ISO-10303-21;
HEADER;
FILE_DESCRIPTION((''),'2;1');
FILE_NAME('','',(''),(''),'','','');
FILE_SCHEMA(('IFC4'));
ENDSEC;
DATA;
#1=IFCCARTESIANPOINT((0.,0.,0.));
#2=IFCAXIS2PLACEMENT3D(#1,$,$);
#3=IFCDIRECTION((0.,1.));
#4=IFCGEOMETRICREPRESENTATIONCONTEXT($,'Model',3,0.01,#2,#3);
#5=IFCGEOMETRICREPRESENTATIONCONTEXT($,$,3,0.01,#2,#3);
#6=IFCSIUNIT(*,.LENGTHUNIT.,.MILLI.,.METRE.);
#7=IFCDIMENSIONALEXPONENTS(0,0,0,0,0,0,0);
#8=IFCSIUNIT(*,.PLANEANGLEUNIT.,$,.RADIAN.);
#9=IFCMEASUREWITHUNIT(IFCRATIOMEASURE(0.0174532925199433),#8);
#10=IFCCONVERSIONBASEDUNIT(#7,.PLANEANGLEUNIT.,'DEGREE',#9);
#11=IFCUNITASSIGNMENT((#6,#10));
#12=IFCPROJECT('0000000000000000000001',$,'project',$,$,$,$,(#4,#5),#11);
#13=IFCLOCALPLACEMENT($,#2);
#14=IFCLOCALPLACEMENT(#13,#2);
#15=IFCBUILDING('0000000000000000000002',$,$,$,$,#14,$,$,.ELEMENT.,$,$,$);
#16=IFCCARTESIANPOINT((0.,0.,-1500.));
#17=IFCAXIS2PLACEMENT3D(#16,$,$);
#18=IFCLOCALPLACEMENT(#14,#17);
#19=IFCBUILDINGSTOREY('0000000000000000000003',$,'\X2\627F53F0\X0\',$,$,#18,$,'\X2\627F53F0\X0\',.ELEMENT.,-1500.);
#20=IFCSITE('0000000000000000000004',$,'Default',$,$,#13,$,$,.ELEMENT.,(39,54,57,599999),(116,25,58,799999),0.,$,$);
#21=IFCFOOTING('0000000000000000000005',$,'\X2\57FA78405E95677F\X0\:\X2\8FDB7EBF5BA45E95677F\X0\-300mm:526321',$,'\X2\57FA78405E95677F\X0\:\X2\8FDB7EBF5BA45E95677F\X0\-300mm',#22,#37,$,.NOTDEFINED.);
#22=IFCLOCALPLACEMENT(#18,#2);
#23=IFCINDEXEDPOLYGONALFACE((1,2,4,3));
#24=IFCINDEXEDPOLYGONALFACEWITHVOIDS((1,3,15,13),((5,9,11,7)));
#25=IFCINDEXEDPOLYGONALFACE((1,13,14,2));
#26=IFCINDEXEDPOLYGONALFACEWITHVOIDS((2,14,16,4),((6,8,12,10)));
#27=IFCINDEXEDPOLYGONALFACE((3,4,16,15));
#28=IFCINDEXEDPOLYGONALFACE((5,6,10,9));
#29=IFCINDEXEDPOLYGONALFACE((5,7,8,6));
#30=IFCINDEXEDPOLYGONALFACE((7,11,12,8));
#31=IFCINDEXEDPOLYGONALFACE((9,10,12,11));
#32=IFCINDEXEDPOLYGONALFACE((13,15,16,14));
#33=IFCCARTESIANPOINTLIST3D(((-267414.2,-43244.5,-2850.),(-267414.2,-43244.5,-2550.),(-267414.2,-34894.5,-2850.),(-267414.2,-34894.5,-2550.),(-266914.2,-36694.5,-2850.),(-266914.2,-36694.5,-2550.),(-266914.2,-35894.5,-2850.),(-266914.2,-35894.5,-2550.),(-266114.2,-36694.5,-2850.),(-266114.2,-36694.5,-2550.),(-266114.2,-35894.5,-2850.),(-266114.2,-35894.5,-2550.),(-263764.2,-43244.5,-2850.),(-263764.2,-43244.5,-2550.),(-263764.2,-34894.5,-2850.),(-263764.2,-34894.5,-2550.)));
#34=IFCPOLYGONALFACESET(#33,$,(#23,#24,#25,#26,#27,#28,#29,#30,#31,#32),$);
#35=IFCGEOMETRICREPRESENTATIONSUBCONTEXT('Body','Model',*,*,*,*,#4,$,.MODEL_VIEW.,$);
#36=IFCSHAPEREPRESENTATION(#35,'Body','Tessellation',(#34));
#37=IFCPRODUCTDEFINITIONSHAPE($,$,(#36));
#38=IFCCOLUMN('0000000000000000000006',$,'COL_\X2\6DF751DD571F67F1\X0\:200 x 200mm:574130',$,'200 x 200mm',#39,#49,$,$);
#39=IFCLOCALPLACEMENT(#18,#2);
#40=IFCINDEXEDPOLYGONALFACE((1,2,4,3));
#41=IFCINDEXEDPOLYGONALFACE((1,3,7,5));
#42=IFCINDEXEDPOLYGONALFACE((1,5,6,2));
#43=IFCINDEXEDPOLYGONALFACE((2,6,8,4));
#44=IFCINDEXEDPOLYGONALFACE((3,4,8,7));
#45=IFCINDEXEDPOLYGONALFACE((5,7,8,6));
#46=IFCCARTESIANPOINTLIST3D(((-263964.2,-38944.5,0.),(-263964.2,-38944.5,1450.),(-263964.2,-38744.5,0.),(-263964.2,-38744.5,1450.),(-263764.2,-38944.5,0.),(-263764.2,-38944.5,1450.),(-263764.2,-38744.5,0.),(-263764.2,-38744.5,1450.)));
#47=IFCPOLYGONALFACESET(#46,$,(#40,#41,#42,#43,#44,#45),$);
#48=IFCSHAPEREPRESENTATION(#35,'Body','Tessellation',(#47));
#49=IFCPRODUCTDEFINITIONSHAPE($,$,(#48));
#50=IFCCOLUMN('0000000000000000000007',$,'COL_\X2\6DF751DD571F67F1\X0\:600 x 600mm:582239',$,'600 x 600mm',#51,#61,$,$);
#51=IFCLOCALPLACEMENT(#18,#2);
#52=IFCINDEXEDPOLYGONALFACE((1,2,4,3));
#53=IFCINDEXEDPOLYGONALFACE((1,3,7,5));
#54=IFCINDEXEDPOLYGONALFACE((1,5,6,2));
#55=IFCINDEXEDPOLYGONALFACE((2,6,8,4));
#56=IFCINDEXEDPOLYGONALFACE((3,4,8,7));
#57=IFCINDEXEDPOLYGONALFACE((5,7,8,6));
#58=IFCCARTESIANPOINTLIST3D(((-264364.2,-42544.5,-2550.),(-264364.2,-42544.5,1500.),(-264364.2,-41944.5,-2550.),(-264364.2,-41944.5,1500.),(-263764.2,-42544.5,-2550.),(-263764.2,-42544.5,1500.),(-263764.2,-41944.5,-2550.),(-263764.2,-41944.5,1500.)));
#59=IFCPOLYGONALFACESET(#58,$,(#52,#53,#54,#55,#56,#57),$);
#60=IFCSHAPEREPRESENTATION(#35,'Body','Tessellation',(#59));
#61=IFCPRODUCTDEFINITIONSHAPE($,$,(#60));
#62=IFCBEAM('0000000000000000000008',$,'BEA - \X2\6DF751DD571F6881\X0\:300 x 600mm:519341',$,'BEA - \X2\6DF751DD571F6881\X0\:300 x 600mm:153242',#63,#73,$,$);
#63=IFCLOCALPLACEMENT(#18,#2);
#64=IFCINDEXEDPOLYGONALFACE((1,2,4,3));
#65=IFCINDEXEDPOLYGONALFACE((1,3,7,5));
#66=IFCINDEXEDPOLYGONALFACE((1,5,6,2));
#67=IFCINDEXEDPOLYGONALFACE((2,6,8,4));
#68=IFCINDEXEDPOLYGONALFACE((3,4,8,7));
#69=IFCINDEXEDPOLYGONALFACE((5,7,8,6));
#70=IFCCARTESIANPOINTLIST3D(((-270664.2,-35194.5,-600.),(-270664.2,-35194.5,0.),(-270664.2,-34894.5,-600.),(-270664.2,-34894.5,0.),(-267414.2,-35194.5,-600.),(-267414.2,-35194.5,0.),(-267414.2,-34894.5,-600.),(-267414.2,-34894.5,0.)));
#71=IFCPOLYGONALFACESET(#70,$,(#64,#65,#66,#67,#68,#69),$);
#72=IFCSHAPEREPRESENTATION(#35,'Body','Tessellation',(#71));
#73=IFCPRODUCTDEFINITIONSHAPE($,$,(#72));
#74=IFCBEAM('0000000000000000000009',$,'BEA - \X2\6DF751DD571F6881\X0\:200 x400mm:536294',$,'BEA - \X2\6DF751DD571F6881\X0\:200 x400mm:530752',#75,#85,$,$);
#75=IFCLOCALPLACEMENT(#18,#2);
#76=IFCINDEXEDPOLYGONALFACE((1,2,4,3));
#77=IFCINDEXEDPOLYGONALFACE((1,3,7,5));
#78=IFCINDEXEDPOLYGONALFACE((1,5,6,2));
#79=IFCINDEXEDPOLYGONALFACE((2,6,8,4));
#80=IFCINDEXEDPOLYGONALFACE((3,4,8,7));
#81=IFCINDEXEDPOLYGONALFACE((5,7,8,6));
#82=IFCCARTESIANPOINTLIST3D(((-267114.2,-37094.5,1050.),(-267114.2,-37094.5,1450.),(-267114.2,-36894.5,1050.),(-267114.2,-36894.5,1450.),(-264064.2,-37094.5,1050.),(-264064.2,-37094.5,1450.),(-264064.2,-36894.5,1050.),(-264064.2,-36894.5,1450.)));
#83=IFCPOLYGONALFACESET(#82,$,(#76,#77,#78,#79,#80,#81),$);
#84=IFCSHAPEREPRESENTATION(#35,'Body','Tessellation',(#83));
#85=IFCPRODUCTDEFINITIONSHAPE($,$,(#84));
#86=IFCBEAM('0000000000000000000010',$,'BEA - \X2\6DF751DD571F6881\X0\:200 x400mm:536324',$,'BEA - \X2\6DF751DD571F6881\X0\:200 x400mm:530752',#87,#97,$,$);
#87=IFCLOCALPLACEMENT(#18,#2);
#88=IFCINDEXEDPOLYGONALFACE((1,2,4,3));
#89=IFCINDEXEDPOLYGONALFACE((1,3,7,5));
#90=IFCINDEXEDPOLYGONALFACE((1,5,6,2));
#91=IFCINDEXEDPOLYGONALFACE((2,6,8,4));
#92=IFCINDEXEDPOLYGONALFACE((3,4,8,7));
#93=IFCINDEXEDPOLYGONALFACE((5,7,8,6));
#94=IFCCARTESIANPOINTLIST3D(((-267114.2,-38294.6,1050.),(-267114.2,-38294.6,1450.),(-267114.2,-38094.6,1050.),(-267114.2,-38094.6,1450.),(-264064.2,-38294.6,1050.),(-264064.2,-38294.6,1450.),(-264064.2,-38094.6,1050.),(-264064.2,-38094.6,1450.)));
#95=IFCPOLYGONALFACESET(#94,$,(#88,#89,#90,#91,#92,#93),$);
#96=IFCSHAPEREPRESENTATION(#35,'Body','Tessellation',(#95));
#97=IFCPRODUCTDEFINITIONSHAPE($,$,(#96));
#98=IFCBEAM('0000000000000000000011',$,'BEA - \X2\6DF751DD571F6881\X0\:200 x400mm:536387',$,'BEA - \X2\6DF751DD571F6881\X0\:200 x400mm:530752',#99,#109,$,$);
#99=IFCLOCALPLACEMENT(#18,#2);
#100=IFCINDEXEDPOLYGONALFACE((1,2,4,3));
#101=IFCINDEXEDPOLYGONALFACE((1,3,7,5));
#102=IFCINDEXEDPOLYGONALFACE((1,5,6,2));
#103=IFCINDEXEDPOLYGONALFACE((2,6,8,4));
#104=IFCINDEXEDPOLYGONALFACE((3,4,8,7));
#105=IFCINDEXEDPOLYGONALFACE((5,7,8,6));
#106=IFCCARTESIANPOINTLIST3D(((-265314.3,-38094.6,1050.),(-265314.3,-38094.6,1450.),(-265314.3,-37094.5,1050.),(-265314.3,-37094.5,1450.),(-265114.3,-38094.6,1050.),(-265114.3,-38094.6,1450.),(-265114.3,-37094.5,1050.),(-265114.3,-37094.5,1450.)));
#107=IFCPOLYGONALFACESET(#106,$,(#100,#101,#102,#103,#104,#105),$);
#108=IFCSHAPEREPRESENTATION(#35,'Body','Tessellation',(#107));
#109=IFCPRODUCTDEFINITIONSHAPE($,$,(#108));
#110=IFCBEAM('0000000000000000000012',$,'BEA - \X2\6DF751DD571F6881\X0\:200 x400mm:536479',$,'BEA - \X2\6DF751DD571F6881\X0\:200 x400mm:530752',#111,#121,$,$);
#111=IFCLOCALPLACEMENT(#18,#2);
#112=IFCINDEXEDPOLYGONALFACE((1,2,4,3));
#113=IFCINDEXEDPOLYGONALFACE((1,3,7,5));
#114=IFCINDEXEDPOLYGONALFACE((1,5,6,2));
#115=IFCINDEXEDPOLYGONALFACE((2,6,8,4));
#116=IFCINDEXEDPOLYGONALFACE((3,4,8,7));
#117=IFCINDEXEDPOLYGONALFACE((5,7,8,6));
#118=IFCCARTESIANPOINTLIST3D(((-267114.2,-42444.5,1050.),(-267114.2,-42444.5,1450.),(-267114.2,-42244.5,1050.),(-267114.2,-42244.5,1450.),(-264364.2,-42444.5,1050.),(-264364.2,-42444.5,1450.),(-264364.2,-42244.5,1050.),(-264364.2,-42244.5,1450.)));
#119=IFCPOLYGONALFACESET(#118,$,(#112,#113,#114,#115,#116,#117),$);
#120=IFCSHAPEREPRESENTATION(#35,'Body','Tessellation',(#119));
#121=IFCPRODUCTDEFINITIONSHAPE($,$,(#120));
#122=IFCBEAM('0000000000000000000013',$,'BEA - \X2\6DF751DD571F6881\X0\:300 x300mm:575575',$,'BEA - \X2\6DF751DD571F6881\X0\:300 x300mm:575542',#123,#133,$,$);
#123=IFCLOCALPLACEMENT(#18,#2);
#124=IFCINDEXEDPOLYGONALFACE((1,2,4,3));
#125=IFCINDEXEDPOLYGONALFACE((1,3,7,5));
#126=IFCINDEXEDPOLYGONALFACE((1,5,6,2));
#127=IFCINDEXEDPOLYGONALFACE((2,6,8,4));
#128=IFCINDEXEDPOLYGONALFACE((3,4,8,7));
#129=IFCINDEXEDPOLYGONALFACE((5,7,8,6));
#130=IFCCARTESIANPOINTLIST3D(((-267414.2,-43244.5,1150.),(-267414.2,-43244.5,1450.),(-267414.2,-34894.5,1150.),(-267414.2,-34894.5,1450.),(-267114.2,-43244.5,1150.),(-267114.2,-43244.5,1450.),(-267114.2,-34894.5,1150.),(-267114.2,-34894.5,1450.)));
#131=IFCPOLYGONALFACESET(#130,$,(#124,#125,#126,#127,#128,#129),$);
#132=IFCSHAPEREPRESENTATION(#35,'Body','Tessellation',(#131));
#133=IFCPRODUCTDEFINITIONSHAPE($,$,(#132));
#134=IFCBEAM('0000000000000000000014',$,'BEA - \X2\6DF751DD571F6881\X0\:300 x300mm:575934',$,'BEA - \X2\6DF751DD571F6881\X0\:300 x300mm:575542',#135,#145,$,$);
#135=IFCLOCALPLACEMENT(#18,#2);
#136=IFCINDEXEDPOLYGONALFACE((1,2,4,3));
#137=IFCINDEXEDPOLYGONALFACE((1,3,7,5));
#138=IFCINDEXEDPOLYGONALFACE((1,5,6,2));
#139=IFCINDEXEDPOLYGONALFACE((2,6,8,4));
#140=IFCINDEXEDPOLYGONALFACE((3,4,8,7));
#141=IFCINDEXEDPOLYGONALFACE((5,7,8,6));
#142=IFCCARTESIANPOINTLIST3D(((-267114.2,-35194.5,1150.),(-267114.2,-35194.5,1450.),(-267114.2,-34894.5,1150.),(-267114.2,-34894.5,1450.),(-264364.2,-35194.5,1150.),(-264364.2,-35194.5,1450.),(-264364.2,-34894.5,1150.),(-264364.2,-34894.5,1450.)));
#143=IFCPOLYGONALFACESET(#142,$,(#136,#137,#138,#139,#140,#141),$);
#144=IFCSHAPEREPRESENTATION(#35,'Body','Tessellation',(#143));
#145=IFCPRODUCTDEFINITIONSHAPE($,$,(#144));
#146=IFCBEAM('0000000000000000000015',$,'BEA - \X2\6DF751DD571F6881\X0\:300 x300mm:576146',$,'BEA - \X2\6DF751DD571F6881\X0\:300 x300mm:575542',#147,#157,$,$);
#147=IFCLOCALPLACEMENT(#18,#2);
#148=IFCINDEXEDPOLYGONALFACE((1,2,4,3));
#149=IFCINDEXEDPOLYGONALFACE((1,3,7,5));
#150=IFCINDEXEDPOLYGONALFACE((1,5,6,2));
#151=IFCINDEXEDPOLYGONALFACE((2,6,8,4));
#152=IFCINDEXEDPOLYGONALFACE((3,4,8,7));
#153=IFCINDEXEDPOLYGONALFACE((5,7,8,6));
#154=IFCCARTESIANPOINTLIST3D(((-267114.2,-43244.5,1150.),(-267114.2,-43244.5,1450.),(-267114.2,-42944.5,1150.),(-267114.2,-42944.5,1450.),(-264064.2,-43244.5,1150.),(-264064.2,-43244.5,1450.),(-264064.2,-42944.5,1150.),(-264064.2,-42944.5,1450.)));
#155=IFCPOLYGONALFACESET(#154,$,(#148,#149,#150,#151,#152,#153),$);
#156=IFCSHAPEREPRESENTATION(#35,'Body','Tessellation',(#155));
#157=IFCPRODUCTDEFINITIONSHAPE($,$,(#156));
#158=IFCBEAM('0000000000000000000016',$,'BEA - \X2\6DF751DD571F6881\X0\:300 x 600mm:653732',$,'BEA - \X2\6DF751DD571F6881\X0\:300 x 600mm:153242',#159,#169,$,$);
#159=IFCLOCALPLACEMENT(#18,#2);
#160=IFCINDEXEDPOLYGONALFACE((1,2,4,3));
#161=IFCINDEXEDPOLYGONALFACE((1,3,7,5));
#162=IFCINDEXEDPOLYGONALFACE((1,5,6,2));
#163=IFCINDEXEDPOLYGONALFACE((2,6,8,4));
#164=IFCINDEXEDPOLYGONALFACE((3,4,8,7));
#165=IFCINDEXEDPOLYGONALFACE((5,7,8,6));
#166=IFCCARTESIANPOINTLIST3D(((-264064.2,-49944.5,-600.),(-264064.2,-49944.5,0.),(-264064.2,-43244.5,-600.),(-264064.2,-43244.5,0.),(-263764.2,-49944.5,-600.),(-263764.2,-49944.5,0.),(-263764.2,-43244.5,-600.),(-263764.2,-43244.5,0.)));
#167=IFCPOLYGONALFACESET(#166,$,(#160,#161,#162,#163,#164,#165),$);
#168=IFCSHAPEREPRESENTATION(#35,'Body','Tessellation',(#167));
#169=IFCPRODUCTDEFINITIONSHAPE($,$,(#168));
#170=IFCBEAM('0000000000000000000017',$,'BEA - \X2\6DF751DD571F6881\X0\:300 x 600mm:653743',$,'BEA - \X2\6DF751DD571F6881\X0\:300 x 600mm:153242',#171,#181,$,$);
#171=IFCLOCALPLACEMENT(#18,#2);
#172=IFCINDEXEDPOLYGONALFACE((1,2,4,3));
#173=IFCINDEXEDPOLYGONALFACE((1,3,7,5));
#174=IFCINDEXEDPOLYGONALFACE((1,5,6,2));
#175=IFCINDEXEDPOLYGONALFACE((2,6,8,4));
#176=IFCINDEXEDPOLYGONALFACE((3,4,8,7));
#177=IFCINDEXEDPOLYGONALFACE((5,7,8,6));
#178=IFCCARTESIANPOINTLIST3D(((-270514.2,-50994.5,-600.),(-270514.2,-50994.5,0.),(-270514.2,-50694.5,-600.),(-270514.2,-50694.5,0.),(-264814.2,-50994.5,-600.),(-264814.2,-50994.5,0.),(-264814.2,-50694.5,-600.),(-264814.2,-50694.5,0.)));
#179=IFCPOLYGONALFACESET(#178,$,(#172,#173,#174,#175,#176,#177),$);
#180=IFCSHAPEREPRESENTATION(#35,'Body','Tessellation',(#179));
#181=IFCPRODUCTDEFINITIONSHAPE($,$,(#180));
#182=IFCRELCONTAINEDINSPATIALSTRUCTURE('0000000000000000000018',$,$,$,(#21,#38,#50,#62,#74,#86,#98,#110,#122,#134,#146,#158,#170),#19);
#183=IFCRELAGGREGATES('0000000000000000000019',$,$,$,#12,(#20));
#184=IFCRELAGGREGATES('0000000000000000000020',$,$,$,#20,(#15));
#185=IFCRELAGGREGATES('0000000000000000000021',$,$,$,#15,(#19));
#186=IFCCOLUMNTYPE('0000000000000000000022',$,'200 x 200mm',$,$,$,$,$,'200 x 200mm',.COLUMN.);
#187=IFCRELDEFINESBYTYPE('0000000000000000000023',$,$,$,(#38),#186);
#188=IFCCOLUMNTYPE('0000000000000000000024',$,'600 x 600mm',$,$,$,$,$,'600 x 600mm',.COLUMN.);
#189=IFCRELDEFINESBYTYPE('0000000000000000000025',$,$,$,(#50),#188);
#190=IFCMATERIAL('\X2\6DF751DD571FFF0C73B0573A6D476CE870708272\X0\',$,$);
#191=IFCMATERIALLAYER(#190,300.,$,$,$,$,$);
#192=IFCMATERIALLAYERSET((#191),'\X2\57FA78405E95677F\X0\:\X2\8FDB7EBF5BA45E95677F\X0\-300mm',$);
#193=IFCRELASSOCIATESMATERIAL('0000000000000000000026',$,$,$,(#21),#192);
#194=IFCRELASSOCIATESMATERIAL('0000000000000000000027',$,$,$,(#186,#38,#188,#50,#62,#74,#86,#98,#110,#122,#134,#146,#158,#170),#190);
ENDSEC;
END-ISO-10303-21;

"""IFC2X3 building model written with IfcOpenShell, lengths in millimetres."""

from ifc_helpers import new_model, entity, si_unit, converted_unit, direction, frame, frame_2d, origin, origin_2d_with_axis, place, context, subcontext, project, spatial, rectangle, extrude, source, transform, mapped, material, layer, layer_set, layer_usage, type_object, type_shapes, element, save


model = new_model("IFC2X3")

# Units and contexts
model_context = context("Model", 3, precision=0.01, world=origin(), true_north=direction((0.0, 1.0)))
context_of_model = context(None, 3, precision=0.01, world=origin(), true_north=direction((0.0, 1.0)))
body_context = subcontext(model_context, "Body", "Model", "MODEL_VIEW")
ifc_project = project(units=[si_unit("LENGTHUNIT", "METRE", prefix="MILLI"), converted_unit("PLANEANGLEUNIT", "DEGREE", entity("IfcRatioMeasure", 0.0174532925199433), si_unit("PLANEANGLEUNIT", "RADIAN"), dimensions=[0, 0, 0, 0, 0, 0, 0])], contexts=[model_context, context_of_model])

# Site, building, storey
site_placement = place(None, origin())
site = spatial("IfcSite", under=ifc_project, at=site_placement, Name="Default", CompositionType="ELEMENT", RefLatitude=(39, 54, 57, 599999), RefLongitude=(116, 25, 58, 799999), RefElevation=0.0)
building_placement = place(site_placement, origin())
building = spatial("IfcBuilding", under=site, at=building_placement, CompositionType="ELEMENT")
storey_placement = place(building_placement, frame((0.0, 0.0, -1500.0)))
storey = spatial("IfcBuildingStorey", under=building, at=storey_placement, Name="承台", LongName="承台", CompositionType="ELEMENT", Elevation=-1500.0)

# Footing, opening
ifc_material_1 = material(Name="混凝土，现场浇注灰色")
ifc_layer_1 = layer(ifc_material_1, 300.0)
ifc_layer_set_1 = layer_set([ifc_layer_1], Name="基础底板:进线室底板-300mm")
ifc_layer_usage_1 = layer_usage(ifc_layer_set_1, "AXIS3", "POSITIVE", 0.0)
footing_1_placement = place(storey_placement, frame((-267414.2, -43244.5, -2850.0)))
footing_1 = element("IfcFooting", 1, at=footing_1_placement, inside=storey, material=ifc_layer_usage_1, Name="基础底板:进线室底板-300mm:526321", ObjectType="基础底板:进线室底板-300mm", PredefinedType="NOTDEFINED", context=body_context, shape_type="SweptSolid", body=[
    extrude(rectangle(XDim=3650.0, YDim=8350.0, at=frame_2d((0.0, 0.0), x_axis=(-1.0, 0.0))), frame((1825.0, 4175.0, 300.0), z_axis=(0.0, 0.0, -1.0), x_axis=(-1.0, 0.0, 0.0)), (0.0, 0.0, 1.0), 300.0),
])
opening_1_placement = place(footing_1_placement, frame((900.0, 6950.0, 300.0)))
element("IfcOpeningElement", 2, at=opening_1_placement, cuts=footing_1, ObjectType="Opening", context=body_context, shape_type="SweptSolid", body=[
    extrude(rectangle(XDim=800.0, YDim=800.0, at=origin_2d_with_axis()), frame((0.0, 0.0, 0.0), z_axis=(0.0, 0.0, -1.0), x_axis=(0.0, 1.0, 0.0)), (0.0, 0.0, 1.0), 300.0),
])

# Columns
column_type_1 = type_object("IfcColumnType", Name="200 x 200mm", ElementType="200 x 200mm", PredefinedType="COLUMN", material=ifc_material_1)
shared_shape_1 = source(origin(), body_context, "Body", "SweptSolid", [
    extrude(rectangle(XDim=200.0, YDim=200.0, at=frame_2d((0.0, 0.0), x_axis=(1.0, 0.0))), frame((100.0, 100.0, 0.0), z_axis=(0.0, 0.0, 1.0), x_axis=(-1.0, 0.0, 0.0)), (0.0, 0.0, 1.0), 1450.0),
])
type_shapes(column_type_1, [shared_shape_1])
column_1_placement = place(storey_placement, frame((-263964.2, -38944.5, 0.0)))
element("IfcColumn", 3, at=column_1_placement, inside=storey, type_object=column_type_1, material=ifc_material_1, Name="COL_混凝土柱:200 x 200mm:574130", ObjectType="200 x 200mm", context=body_context, shape_type="MappedRepresentation", body=[
    mapped(shared_shape_1, transform((0.0, 0.0, 0.0), scale=1.0)),
])
column_type_2 = type_object("IfcColumnType", Name="600 x 600mm", ElementType="600 x 600mm", PredefinedType="COLUMN", material=ifc_material_1)
shared_shape_2 = source(origin(), body_context, "Body", "SweptSolid", [
    extrude(rectangle(XDim=600.0, YDim=600.0, at=frame_2d((0.0, 0.0), x_axis=(1.0, 0.0))), frame((300.0, 300.0, 0.0), z_axis=(0.0, 0.0, 1.0), x_axis=(-1.0, 0.0, 0.0)), (0.0, 0.0, 1.0), 4050.0),
])
type_shapes(column_type_2, [shared_shape_2])
column_2_placement = place(storey_placement, frame((-264364.2, -42544.5, -2550.0)))
element("IfcColumn", 4, at=column_2_placement, inside=storey, type_object=column_type_2, material=ifc_material_1, Name="COL_混凝土柱:600 x 600mm:582239", ObjectType="600 x 600mm", context=body_context, shape_type="MappedRepresentation", body=[
    mapped(shared_shape_2, transform((0.0, 0.0, 0.0), scale=1.0)),
])

# Beams
beam_1_placement = place(storey_placement, frame((-267264.2, -35044.5, 0.0), z_axis=(0.0, 0.0, 1.0), x_axis=(-1.0, 0.0, 0.0)))
element("IfcBeam", 5, at=beam_1_placement, inside=storey, material=ifc_material_1, Name="BEA - 混凝土梁:300 x 600mm:519341", ObjectType="BEA - 混凝土梁:300 x 600mm:153242", context=body_context, shape_type="SweptSolid", body=[
    extrude(rectangle(XDim=600.0, YDim=300.0, at=frame_2d((0.0, 0.0), x_axis=(1.0, 0.0))), frame((150.0, 0.0, -300.0), z_axis=(1.0, 0.0, 0.0), x_axis=(0.0, 0.0, -1.0)), (0.0, 0.0, 1.0), 3250.0),
])
beam_2_placement = place(storey_placement, frame((-267114.2, -36994.5, 1450.0)))
element("IfcBeam", 6, at=beam_2_placement, inside=storey, material=ifc_material_1, Name="BEA - 混凝土梁:200 x400mm:536294", ObjectType="BEA - 混凝土梁:200 x400mm:530752", context=body_context, shape_type="SweptSolid", body=[
    extrude(rectangle(XDim=400.0, YDim=200.0, at=frame_2d((0.0, 0.0), x_axis=(1.0, 0.0))), frame((0.0, 0.0, -200.0), z_axis=(1.0, 0.0, 0.0), x_axis=(0.0, 0.0, -1.0)), (0.0, 0.0, 1.0), 3050.0),
])
beam_3_placement = place(storey_placement, frame((-267114.2, -38194.6, 1450.0)))
element("IfcBeam", 7, at=beam_3_placement, inside=storey, material=ifc_material_1, Name="BEA - 混凝土梁:200 x400mm:536324", ObjectType="BEA - 混凝土梁:200 x400mm:530752", context=body_context, shape_type="SweptSolid", body=[
    extrude(rectangle(XDim=400.0, YDim=200.0, at=frame_2d((0.0, 0.0), x_axis=(1.0, 0.0))), frame((0.0, 0.0, -200.0), z_axis=(1.0, 0.0, 0.0), x_axis=(0.0, 0.0, -1.0)), (0.0, 0.0, 1.0), 3050.0),
])
beam_4_placement = place(storey_placement, frame((-265214.3, -37094.5, 1450.0), z_axis=(0.0, 0.0, 1.0), x_axis=(0.0, -1.0, 0.0)))
element("IfcBeam", 8, at=beam_4_placement, inside=storey, material=ifc_material_1, Name="BEA - 混凝土梁:200 x400mm:536387", ObjectType="BEA - 混凝土梁:200 x400mm:530752", context=body_context, shape_type="SweptSolid", body=[
    extrude(rectangle(XDim=400.0, YDim=200.0, at=frame_2d((0.0, 0.0), x_axis=(1.0, 0.0))), frame((0.0, 0.0, -200.0), z_axis=(1.0, 0.0, 0.0), x_axis=(0.0, 0.0, -1.0)), (0.0, 0.0, 1.0), 1000.1),
])
beam_5_placement = place(storey_placement, frame((-267114.2, -42344.5, 1450.0)))
element("IfcBeam", 9, at=beam_5_placement, inside=storey, material=ifc_material_1, Name="BEA - 混凝土梁:200 x400mm:536479", ObjectType="BEA - 混凝土梁:200 x400mm:530752", context=body_context, shape_type="SweptSolid", body=[
    extrude(rectangle(XDim=400.0, YDim=200.0, at=frame_2d((0.0, 0.0), x_axis=(1.0, 0.0))), frame((0.0, 0.0, -200.0), z_axis=(1.0, 0.0, 0.0), x_axis=(0.0, 0.0, -1.0)), (0.0, 0.0, 1.0), 2750.0),
])
beam_6_placement = place(storey_placement, frame((-267264.2, -43094.5, 1450.0), z_axis=(0.0, 0.0, 1.0), x_axis=(0.0, 1.0, 0.0)))
element("IfcBeam", 10, at=beam_6_placement, inside=storey, material=ifc_material_1, Name="BEA - 混凝土梁:300 x300mm:575575", ObjectType="BEA - 混凝土梁:300 x300mm:575542", context=body_context, shape_type="SweptSolid", body=[
    extrude(rectangle(XDim=300.0, YDim=300.0, at=frame_2d((0.0, 0.0), x_axis=(1.0, 0.0))), frame((-150.0, 0.0, -150.0), z_axis=(1.0, 0.0, 0.0), x_axis=(0.0, 0.0, -1.0)), (0.0, 0.0, 1.0), 8350.0),
])
beam_7_placement = place(storey_placement, frame((-267114.2, -35044.5, 1450.0)))
element("IfcBeam", 11, at=beam_7_placement, inside=storey, material=ifc_material_1, Name="BEA - 混凝土梁:300 x300mm:575934", ObjectType="BEA - 混凝土梁:300 x300mm:575542", context=body_context, shape_type="SweptSolid", body=[
    extrude(rectangle(XDim=300.0, YDim=300.0, at=frame_2d((0.0, 0.0), x_axis=(1.0, 0.0))), frame((0.0, 0.0, -150.0), z_axis=(1.0, 0.0, 0.0), x_axis=(0.0, 0.0, -1.0)), (0.0, 0.0, 1.0), 2750.0),
])
beam_8_placement = place(storey_placement, frame((-267114.2, -43094.5, 1450.0)))
element("IfcBeam", 12, at=beam_8_placement, inside=storey, material=ifc_material_1, Name="BEA - 混凝土梁:300 x300mm:576146", ObjectType="BEA - 混凝土梁:300 x300mm:575542", context=body_context, shape_type="SweptSolid", body=[
    extrude(rectangle(XDim=300.0, YDim=300.0, at=frame_2d((0.0, 0.0), x_axis=(1.0, 0.0))), frame((0.0, 0.0, -150.0), z_axis=(1.0, 0.0, 0.0), x_axis=(0.0, 0.0, -1.0)), (0.0, 0.0, 1.0), 3050.0),
])
beam_9_placement = place(storey_placement, frame((-263914.2, -49944.5, 0.0), z_axis=(0.0, 0.0, 1.0), x_axis=(0.0, 1.0, 0.0)))
element("IfcBeam", 13, at=beam_9_placement, inside=storey, material=ifc_material_1, Name="BEA - 混凝土梁:300 x 600mm:653732", ObjectType="BEA - 混凝土梁:300 x 600mm:153242", context=body_context, shape_type="SweptSolid", body=[
    extrude(rectangle(XDim=600.0, YDim=300.0, at=origin_2d_with_axis()), frame((0.0, 0.0, -300.0), z_axis=(1.0, 0.0, 0.0), x_axis=(0.0, 0.0, -1.0)), (0.0, 0.0, 1.0), 6700.0),
])
beam_10_placement = place(storey_placement, frame((-264814.2, -50844.5, 0.0), z_axis=(0.0, 0.0, 1.0), x_axis=(-1.0, 0.0, 0.0)))
element("IfcBeam", 14, at=beam_10_placement, inside=storey, material=ifc_material_1, Name="BEA - 混凝土梁:300 x 600mm:653743", ObjectType="BEA - 混凝土梁:300 x 600mm:153242", context=body_context, shape_type="SweptSolid", body=[
    extrude(rectangle(XDim=600.0, YDim=300.0, at=frame_2d((0.0, 0.0), x_axis=(1.0, 0.0))), frame((0.0, 0.0, -300.0), z_axis=(1.0, 0.0, 0.0), x_axis=(0.0, 0.0, -1.0)), (0.0, 0.0, 1.0), 5700.0),
])

save(model, "model.ifc")
